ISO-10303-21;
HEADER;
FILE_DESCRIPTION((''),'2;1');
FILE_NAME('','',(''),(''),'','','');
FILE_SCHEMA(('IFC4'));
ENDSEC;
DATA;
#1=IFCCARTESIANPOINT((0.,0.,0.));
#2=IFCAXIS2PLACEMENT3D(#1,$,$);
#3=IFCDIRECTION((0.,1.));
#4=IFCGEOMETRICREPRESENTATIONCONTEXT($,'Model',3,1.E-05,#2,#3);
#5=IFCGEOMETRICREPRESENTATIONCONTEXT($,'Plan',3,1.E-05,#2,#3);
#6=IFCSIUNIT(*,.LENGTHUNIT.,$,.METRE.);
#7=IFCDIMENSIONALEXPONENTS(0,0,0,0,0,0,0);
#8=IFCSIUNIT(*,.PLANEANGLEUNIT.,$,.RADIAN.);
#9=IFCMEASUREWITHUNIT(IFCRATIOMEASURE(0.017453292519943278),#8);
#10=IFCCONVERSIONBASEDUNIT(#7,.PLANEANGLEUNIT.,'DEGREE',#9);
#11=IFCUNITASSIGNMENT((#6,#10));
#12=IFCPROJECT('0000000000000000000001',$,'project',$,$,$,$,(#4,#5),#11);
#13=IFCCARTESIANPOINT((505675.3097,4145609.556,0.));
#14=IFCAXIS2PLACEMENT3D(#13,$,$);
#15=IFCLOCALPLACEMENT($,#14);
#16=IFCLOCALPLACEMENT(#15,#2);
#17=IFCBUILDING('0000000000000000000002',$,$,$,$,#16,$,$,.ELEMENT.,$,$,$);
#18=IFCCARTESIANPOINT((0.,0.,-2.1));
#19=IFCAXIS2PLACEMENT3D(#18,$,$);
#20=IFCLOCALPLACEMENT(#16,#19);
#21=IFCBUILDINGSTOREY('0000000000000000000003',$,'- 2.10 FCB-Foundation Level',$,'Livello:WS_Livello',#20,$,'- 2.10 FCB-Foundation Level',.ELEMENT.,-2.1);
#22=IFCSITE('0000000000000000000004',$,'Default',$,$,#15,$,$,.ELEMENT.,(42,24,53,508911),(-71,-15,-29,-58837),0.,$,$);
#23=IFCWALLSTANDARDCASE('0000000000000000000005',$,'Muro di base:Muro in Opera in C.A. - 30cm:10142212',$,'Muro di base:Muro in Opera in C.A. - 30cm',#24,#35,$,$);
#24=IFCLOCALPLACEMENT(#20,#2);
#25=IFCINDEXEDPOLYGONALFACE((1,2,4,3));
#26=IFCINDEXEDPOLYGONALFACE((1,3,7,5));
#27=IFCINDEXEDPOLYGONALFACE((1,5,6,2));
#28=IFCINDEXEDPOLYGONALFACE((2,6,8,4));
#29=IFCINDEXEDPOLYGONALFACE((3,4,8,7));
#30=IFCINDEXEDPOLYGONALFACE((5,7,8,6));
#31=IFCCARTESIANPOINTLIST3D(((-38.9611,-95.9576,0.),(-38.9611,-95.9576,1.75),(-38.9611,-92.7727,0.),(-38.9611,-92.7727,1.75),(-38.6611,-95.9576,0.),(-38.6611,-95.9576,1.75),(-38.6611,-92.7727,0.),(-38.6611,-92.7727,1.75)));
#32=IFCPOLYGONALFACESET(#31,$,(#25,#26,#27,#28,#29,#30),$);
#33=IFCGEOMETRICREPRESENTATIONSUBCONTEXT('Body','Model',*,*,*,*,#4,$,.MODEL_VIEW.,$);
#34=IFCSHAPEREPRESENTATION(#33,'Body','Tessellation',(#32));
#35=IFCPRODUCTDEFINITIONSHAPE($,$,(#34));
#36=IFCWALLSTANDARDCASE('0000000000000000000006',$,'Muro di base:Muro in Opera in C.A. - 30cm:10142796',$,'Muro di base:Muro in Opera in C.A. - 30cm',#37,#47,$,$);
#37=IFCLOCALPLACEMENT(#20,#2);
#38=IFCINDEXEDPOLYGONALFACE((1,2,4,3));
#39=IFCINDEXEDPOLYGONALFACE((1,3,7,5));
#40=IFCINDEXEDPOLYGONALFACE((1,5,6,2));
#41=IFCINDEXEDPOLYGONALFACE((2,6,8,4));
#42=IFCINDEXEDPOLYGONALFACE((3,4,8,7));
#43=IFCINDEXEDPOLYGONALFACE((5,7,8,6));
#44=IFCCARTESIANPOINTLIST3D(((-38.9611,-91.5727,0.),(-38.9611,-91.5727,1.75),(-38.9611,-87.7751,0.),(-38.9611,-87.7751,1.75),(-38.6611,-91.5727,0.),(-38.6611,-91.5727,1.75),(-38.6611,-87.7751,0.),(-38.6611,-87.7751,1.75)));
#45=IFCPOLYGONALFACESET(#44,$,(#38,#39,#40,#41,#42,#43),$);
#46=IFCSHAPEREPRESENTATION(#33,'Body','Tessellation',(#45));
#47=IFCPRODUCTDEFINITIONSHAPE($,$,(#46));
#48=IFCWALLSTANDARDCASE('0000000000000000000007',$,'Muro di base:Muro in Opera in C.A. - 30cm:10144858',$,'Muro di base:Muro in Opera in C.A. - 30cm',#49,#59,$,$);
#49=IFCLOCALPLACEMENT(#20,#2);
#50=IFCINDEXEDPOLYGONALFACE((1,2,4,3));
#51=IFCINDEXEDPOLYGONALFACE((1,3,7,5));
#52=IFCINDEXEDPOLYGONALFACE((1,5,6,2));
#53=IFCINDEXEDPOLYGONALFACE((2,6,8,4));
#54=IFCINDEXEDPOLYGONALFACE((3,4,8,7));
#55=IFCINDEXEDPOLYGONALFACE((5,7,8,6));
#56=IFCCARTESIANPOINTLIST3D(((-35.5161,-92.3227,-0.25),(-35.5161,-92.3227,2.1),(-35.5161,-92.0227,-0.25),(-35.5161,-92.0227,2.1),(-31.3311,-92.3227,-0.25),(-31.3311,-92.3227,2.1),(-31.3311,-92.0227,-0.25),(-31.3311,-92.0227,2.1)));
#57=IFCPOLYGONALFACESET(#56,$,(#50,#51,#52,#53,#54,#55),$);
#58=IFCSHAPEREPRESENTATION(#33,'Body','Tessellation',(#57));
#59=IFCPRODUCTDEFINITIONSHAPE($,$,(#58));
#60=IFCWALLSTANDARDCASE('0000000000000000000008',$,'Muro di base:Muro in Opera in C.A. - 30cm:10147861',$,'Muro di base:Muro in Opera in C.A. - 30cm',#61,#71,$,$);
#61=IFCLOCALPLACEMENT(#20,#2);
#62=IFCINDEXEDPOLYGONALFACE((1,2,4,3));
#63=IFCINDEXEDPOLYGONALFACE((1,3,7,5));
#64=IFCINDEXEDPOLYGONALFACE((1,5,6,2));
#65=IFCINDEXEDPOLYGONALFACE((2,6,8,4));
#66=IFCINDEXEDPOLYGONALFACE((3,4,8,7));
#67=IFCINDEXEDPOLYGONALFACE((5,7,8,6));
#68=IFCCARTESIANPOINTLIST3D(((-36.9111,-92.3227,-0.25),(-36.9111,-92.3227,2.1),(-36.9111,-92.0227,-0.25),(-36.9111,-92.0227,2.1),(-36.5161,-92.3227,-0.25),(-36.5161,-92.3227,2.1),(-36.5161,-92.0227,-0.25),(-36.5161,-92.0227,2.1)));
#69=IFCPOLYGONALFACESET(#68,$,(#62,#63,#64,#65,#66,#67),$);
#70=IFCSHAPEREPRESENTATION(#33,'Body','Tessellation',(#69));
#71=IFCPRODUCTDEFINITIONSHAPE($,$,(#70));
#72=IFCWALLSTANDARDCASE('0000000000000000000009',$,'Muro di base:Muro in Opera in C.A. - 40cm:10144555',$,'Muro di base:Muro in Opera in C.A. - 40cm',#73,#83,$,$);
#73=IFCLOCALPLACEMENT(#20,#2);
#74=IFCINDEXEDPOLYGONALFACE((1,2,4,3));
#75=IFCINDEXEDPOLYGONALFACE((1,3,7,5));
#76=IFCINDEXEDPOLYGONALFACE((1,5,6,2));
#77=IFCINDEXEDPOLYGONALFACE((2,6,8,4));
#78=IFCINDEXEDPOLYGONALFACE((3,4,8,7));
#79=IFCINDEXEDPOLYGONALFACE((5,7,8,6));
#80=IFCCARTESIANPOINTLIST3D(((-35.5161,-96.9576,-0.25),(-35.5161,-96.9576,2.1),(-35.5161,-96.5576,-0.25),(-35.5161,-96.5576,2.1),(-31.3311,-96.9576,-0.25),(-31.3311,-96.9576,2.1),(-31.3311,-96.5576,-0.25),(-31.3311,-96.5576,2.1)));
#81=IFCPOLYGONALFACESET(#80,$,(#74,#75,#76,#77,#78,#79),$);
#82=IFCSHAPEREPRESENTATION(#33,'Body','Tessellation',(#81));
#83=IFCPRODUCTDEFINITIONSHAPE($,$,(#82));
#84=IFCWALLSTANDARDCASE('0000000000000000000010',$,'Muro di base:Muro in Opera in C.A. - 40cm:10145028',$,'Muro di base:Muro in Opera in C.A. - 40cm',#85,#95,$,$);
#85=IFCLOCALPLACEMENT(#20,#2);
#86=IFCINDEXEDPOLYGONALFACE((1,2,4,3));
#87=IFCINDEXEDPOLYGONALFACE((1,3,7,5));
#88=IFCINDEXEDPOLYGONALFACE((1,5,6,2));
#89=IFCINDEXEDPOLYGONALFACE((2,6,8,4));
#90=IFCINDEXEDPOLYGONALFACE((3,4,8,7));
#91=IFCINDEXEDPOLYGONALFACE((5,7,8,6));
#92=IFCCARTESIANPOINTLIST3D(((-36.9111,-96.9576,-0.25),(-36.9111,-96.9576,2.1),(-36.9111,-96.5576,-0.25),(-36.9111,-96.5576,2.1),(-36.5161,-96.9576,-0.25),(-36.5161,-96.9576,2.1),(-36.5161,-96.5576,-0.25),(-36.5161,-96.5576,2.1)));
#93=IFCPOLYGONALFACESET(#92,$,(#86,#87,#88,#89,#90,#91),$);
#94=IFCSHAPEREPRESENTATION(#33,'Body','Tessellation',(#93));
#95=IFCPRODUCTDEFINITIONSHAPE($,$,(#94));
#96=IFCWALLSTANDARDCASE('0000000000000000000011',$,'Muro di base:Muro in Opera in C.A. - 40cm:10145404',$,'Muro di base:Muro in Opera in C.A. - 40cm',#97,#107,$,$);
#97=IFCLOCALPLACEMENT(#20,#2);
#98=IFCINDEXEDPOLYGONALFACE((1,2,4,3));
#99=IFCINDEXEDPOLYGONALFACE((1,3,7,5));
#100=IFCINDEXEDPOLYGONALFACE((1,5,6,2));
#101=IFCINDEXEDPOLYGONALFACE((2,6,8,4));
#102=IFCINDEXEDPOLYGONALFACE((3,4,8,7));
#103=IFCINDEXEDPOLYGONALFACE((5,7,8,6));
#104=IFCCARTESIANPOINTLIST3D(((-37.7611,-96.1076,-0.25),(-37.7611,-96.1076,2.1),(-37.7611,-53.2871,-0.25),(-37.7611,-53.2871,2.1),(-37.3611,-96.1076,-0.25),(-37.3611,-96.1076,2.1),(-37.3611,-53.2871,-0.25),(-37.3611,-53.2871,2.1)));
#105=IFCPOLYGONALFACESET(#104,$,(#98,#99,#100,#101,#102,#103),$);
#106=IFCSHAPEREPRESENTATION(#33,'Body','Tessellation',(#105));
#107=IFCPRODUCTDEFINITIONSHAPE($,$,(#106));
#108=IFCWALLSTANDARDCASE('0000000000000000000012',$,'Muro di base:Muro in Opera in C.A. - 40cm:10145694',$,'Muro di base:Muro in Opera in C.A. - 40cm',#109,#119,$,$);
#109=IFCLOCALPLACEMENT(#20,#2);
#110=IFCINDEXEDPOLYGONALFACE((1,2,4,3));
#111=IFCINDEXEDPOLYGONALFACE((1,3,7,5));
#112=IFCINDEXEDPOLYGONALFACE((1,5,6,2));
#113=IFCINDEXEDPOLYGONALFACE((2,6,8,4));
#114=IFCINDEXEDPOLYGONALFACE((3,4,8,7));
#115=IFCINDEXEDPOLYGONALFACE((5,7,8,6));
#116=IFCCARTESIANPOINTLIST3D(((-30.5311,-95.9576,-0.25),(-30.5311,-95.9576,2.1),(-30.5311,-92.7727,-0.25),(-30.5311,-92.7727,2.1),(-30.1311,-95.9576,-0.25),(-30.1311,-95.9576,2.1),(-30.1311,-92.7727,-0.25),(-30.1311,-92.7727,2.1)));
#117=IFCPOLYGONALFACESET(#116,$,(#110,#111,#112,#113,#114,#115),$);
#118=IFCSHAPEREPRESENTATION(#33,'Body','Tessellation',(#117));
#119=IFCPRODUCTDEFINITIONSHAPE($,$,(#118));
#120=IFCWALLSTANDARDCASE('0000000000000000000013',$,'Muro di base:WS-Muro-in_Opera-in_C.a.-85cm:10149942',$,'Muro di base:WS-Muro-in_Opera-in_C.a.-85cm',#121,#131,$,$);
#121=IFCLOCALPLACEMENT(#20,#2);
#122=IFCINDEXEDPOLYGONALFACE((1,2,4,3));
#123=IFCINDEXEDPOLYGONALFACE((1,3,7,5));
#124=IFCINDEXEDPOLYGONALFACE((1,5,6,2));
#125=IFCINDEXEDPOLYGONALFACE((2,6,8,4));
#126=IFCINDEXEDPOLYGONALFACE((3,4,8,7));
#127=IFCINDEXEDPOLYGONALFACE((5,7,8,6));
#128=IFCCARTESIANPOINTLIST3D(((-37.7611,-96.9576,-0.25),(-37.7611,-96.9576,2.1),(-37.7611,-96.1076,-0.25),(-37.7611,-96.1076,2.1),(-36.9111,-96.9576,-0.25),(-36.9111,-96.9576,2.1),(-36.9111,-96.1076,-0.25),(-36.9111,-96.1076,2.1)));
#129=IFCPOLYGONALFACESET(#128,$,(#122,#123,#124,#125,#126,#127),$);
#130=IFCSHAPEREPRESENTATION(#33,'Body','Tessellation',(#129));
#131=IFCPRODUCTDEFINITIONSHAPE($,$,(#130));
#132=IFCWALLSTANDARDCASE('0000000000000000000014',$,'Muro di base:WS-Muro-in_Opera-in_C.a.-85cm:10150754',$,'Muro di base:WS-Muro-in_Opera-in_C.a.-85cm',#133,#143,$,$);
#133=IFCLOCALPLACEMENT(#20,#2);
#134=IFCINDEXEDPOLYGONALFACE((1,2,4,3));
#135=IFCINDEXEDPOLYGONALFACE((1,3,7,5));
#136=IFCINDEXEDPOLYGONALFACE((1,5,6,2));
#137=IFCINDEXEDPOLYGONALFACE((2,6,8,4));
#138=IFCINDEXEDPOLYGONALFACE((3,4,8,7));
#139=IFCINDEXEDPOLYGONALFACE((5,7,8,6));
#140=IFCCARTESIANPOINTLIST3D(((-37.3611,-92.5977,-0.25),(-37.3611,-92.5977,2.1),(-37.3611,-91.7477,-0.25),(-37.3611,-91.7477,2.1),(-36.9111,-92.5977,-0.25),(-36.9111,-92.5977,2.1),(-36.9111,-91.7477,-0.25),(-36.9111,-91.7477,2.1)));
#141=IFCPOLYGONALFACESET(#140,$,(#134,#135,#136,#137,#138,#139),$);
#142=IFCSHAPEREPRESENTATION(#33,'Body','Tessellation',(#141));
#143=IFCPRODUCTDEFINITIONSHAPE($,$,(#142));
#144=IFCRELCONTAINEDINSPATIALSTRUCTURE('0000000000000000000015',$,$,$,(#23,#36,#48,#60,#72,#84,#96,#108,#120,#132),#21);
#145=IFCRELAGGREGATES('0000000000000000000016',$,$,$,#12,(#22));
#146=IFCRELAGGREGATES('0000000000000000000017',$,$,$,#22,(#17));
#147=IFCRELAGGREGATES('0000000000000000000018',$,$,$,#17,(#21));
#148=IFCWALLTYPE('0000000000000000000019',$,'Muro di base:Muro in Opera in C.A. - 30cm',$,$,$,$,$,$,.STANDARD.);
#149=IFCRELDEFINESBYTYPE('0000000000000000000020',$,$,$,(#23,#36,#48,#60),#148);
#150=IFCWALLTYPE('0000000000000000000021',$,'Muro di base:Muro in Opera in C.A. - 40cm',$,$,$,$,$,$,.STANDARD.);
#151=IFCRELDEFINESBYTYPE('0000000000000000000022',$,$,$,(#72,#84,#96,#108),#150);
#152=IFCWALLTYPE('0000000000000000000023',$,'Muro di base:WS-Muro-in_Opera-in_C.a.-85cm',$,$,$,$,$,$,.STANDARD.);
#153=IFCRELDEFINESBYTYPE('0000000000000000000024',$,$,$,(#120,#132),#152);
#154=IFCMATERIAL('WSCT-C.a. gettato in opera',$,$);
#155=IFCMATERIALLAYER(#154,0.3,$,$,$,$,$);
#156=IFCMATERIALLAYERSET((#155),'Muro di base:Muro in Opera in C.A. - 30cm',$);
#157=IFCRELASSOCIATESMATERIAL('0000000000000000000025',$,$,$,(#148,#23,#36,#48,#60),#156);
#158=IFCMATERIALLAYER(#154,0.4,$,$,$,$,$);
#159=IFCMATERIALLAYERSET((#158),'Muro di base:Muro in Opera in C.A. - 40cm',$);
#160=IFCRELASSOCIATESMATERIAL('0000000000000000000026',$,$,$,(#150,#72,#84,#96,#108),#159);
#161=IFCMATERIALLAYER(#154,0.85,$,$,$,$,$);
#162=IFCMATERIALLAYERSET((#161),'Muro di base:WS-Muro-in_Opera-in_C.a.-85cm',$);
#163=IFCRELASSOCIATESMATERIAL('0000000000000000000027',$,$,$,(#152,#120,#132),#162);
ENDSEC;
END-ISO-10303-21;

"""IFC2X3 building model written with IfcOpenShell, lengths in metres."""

from ifc_helpers import new_model, entity, si_unit, converted_unit, direction, frame, frame_2d, origin, place, context, subcontext, project, spatial, rectangle, extrude, material, layer, layer_set, layer_usage, type_object, element, save


model = new_model("IFC2X3")

# Units and contexts
model_context = context("Model", 3, precision=1e-05, world=origin(), true_north=direction((0.0, 1.0)))
plan_context = context("Plan", 3, precision=1e-05, world=origin(), true_north=direction((0.0, 1.0)))
body_context = subcontext(model_context, "Body", "Model", "MODEL_VIEW")
ifc_project = project(units=[si_unit("LENGTHUNIT", "METRE"), converted_unit("PLANEANGLEUNIT", "DEGREE", entity("IfcRatioMeasure", 0.017453292519943278), si_unit("PLANEANGLEUNIT", "RADIAN"), dimensions=[0, 0, 0, 0, 0, 0, 0])], contexts=[model_context, plan_context])

# Site, building, storey
site_placement = place(None, frame((505675.3097, 4145609.556, 0.0)))
site = spatial("IfcSite", under=ifc_project, at=site_placement, Name="Default", CompositionType="ELEMENT", RefLatitude=(42, 24, 53, 508911), RefLongitude=(-71, -15, -29, -58837), RefElevation=0.0)
building_placement = place(site_placement, origin())
building = spatial("IfcBuilding", under=site, at=building_placement, CompositionType="ELEMENT")
storey_placement = place(building_placement, frame((0.0, 0.0, -2.1)))
storey = spatial("IfcBuildingStorey", under=building, at=storey_placement, Name="- 2.10 FCB-Foundation Level", ObjectType="Livello:WS_Livello", LongName="- 2.10 FCB-Foundation Level", CompositionType="ELEMENT", Elevation=-2.1)

# Walls
ifc_material_1 = material(Name="WSCT-C.a. gettato in opera")
ifc_layer_1 = layer(ifc_material_1, 0.3)
ifc_layer_set_1 = layer_set([ifc_layer_1], Name="Muro di base:Muro in Opera in C.A. - 30cm")
ifc_layer_usage_1 = layer_usage(ifc_layer_set_1, "AXIS2", "NEGATIVE", 0.15)
wall_type_1 = type_object("IfcWallType", Name="Muro di base:Muro in Opera in C.A. - 30cm", PredefinedType="STANDARD", material=ifc_layer_set_1)
wall_1_placement = place(storey_placement, frame((-38.8111, -95.9576, 0.0), z_axis=(0.0, 0.0, 1.0), x_axis=(0.0, 1.0, 0.0)))
element("IfcWallStandardCase", 1, at=wall_1_placement, inside=storey, type_object=wall_type_1, material=ifc_layer_usage_1, Name="Muro di base:Muro in Opera in C.A. - 30cm:10142212", ObjectType="Muro di base:Muro in Opera in C.A. - 30cm", context=body_context, shape_type="SweptSolid", body=[
    extrude(rectangle(XDim=3.1849, YDim=0.3, at=frame_2d((1.5924, 0.0), x_axis=(-1.0, 0.0))), origin(), (0.0, 0.0, 1.0), 1.75),
])
wall_2_placement = place(storey_placement, frame((-38.8111, -91.5727, 0.0), z_axis=(0.0, 0.0, 1.0), x_axis=(0.0, 1.0, 0.0)))
element("IfcWallStandardCase", 2, at=wall_2_placement, inside=storey, type_object=wall_type_1, material=ifc_layer_usage_1, Name="Muro di base:Muro in Opera in C.A. - 30cm:10142796", ObjectType="Muro di base:Muro in Opera in C.A. - 30cm", context=body_context, shape_type="SweptSolid", body=[
    extrude(rectangle(XDim=3.7976, YDim=0.3, at=frame_2d((1.8988, 0.0), x_axis=(-1.0, 0.0))), origin(), (0.0, 0.0, 1.0), 1.75),
])
wall_3_placement = place(storey_placement, frame((-35.5161, -92.1727, -0.25)))
element("IfcWallStandardCase", 3, at=wall_3_placement, inside=storey, type_object=wall_type_1, material=ifc_layer_usage_1, Name="Muro di base:Muro in Opera in C.A. - 30cm:10144858", ObjectType="Muro di base:Muro in Opera in C.A. - 30cm", context=body_context, shape_type="SweptSolid", body=[
    extrude(rectangle(XDim=4.1851, YDim=0.3, at=frame_2d((2.0925, 0.0), x_axis=(-1.0, 0.0))), origin(), (0.0, 0.0, 1.0), 2.35),
])
wall_4_placement = place(storey_placement, frame((-36.5161, -92.1727, -0.25), z_axis=(0.0, 0.0, 1.0), x_axis=(-1.0, 0.0, 0.0)))
element("IfcWallStandardCase", 4, at=wall_4_placement, inside=storey, type_object=wall_type_1, material=ifc_layer_usage_1, Name="Muro di base:Muro in Opera in C.A. - 30cm:10147861", ObjectType="Muro di base:Muro in Opera in C.A. - 30cm", context=body_context, shape_type="SweptSolid", body=[
    extrude(rectangle(XDim=0.3949, YDim=0.3, at=frame_2d((0.1975, 0.0), x_axis=(-1.0, 0.0))), origin(), (0.0, 0.0, 1.0), 2.35),
])
ifc_layer_2 = layer(ifc_material_1, 0.4)
ifc_layer_set_2 = layer_set([ifc_layer_2], Name="Muro di base:Muro in Opera in C.A. - 40cm")
ifc_layer_usage_2 = layer_usage(ifc_layer_set_2, "AXIS2", "NEGATIVE", 0.2)
wall_type_2 = type_object("IfcWallType", Name="Muro di base:Muro in Opera in C.A. - 40cm", PredefinedType="STANDARD", material=ifc_layer_set_2)
wall_5_placement = place(storey_placement, frame((-35.5161, -96.7576, -0.25)))
element("IfcWallStandardCase", 5, at=wall_5_placement, inside=storey, type_object=wall_type_2, material=ifc_layer_usage_2, Name="Muro di base:Muro in Opera in C.A. - 40cm:10144555", ObjectType="Muro di base:Muro in Opera in C.A. - 40cm", context=body_context, shape_type="SweptSolid", body=[
    extrude(rectangle(XDim=4.1851, YDim=0.4, at=frame_2d((2.0925, 0.0), x_axis=(-1.0, 0.0))), origin(), (0.0, 0.0, 1.0), 2.35),
])
wall_6_placement = place(storey_placement, frame((-36.5161, -96.7576, -0.25), z_axis=(0.0, 0.0, 1.0), x_axis=(-1.0, 0.0, 0.0)))
element("IfcWallStandardCase", 6, at=wall_6_placement, inside=storey, type_object=wall_type_2, material=ifc_layer_usage_2, Name="Muro di base:Muro in Opera in C.A. - 40cm:10145028", ObjectType="Muro di base:Muro in Opera in C.A. - 40cm", context=body_context, shape_type="SweptSolid", body=[
    extrude(rectangle(XDim=0.395, YDim=0.4, at=frame_2d((0.1975, 0.0), x_axis=(-1.0, 0.0))), origin(), (0.0, 0.0, 1.0), 2.35),
])
wall_7_placement = place(storey_placement, frame((-37.5611, -96.1076, -0.25), z_axis=(0.0, 0.0, 1.0), x_axis=(0.0, 1.0, 0.0)))
element("IfcWallStandardCase", 7, at=wall_7_placement, inside=storey, type_object=wall_type_2, material=ifc_layer_usage_2, Name="Muro di base:Muro in Opera in C.A. - 40cm:10145404", ObjectType="Muro di base:Muro in Opera in C.A. - 40cm", context=body_context, shape_type="SweptSolid", body=[
    extrude(rectangle(XDim=42.8206, YDim=0.4, at=frame_2d((21.4103, 0.0), x_axis=(-1.0, 0.0))), origin(), (0.0, 0.0, 1.0), 2.35),
])
wall_8_placement = place(storey_placement, frame((-30.3311, -95.9576, -0.25), z_axis=(0.0, 0.0, 1.0), x_axis=(0.0, 1.0, 0.0)))
element("IfcWallStandardCase", 8, at=wall_8_placement, inside=storey, type_object=wall_type_2, material=ifc_layer_usage_2, Name="Muro di base:Muro in Opera in C.A. - 40cm:10145694", ObjectType="Muro di base:Muro in Opera in C.A. - 40cm", context=body_context, shape_type="SweptSolid", body=[
    extrude(rectangle(XDim=3.1849, YDim=0.4, at=frame_2d((1.5924, 0.0), x_axis=(-1.0, 0.0))), origin(), (0.0, 0.0, 1.0), 2.35),
])
ifc_layer_3 = layer(ifc_material_1, 0.85)
ifc_layer_set_3 = layer_set([ifc_layer_3], Name="Muro di base:WS-Muro-in_Opera-in_C.a.-85cm")
ifc_layer_usage_3 = layer_usage(ifc_layer_set_3, "AXIS2", "NEGATIVE", 0.425)
wall_type_3 = type_object("IfcWallType", Name="Muro di base:WS-Muro-in_Opera-in_C.a.-85cm", PredefinedType="STANDARD", material=ifc_layer_set_3)
wall_9_placement = place(storey_placement, frame((-37.3361, -96.9576, -0.25), z_axis=(0.0, 0.0, 1.0), x_axis=(0.0, 1.0, 0.0)))
element("IfcWallStandardCase", 9, at=wall_9_placement, inside=storey, type_object=wall_type_3, material=ifc_layer_usage_3, Name="Muro di base:WS-Muro-in_Opera-in_C.a.-85cm:10149942", ObjectType="Muro di base:WS-Muro-in_Opera-in_C.a.-85cm", context=body_context, shape_type="SweptSolid", body=[
    extrude(rectangle(XDim=0.85, YDim=0.85, at=frame_2d((0.425, 0.0), x_axis=(-1.0, 0.0))), origin(), (0.0, 0.0, 1.0), 2.35),
])
wall_10_placement = place(storey_placement, frame((-37.3611, -92.1727, -0.25)))
element("IfcWallStandardCase", 10, at=wall_10_placement, inside=storey, type_object=wall_type_3, material=ifc_layer_usage_3, Name="Muro di base:WS-Muro-in_Opera-in_C.a.-85cm:10150754", ObjectType="Muro di base:WS-Muro-in_Opera-in_C.a.-85cm", context=body_context, shape_type="SweptSolid", body=[
    extrude(rectangle(XDim=0.45, YDim=0.85, at=frame_2d((0.225, 0.0), x_axis=(-1.0, 0.0))), origin(), (0.0, 0.0, 1.0), 2.35),
])

save(model, "model.ifc")
